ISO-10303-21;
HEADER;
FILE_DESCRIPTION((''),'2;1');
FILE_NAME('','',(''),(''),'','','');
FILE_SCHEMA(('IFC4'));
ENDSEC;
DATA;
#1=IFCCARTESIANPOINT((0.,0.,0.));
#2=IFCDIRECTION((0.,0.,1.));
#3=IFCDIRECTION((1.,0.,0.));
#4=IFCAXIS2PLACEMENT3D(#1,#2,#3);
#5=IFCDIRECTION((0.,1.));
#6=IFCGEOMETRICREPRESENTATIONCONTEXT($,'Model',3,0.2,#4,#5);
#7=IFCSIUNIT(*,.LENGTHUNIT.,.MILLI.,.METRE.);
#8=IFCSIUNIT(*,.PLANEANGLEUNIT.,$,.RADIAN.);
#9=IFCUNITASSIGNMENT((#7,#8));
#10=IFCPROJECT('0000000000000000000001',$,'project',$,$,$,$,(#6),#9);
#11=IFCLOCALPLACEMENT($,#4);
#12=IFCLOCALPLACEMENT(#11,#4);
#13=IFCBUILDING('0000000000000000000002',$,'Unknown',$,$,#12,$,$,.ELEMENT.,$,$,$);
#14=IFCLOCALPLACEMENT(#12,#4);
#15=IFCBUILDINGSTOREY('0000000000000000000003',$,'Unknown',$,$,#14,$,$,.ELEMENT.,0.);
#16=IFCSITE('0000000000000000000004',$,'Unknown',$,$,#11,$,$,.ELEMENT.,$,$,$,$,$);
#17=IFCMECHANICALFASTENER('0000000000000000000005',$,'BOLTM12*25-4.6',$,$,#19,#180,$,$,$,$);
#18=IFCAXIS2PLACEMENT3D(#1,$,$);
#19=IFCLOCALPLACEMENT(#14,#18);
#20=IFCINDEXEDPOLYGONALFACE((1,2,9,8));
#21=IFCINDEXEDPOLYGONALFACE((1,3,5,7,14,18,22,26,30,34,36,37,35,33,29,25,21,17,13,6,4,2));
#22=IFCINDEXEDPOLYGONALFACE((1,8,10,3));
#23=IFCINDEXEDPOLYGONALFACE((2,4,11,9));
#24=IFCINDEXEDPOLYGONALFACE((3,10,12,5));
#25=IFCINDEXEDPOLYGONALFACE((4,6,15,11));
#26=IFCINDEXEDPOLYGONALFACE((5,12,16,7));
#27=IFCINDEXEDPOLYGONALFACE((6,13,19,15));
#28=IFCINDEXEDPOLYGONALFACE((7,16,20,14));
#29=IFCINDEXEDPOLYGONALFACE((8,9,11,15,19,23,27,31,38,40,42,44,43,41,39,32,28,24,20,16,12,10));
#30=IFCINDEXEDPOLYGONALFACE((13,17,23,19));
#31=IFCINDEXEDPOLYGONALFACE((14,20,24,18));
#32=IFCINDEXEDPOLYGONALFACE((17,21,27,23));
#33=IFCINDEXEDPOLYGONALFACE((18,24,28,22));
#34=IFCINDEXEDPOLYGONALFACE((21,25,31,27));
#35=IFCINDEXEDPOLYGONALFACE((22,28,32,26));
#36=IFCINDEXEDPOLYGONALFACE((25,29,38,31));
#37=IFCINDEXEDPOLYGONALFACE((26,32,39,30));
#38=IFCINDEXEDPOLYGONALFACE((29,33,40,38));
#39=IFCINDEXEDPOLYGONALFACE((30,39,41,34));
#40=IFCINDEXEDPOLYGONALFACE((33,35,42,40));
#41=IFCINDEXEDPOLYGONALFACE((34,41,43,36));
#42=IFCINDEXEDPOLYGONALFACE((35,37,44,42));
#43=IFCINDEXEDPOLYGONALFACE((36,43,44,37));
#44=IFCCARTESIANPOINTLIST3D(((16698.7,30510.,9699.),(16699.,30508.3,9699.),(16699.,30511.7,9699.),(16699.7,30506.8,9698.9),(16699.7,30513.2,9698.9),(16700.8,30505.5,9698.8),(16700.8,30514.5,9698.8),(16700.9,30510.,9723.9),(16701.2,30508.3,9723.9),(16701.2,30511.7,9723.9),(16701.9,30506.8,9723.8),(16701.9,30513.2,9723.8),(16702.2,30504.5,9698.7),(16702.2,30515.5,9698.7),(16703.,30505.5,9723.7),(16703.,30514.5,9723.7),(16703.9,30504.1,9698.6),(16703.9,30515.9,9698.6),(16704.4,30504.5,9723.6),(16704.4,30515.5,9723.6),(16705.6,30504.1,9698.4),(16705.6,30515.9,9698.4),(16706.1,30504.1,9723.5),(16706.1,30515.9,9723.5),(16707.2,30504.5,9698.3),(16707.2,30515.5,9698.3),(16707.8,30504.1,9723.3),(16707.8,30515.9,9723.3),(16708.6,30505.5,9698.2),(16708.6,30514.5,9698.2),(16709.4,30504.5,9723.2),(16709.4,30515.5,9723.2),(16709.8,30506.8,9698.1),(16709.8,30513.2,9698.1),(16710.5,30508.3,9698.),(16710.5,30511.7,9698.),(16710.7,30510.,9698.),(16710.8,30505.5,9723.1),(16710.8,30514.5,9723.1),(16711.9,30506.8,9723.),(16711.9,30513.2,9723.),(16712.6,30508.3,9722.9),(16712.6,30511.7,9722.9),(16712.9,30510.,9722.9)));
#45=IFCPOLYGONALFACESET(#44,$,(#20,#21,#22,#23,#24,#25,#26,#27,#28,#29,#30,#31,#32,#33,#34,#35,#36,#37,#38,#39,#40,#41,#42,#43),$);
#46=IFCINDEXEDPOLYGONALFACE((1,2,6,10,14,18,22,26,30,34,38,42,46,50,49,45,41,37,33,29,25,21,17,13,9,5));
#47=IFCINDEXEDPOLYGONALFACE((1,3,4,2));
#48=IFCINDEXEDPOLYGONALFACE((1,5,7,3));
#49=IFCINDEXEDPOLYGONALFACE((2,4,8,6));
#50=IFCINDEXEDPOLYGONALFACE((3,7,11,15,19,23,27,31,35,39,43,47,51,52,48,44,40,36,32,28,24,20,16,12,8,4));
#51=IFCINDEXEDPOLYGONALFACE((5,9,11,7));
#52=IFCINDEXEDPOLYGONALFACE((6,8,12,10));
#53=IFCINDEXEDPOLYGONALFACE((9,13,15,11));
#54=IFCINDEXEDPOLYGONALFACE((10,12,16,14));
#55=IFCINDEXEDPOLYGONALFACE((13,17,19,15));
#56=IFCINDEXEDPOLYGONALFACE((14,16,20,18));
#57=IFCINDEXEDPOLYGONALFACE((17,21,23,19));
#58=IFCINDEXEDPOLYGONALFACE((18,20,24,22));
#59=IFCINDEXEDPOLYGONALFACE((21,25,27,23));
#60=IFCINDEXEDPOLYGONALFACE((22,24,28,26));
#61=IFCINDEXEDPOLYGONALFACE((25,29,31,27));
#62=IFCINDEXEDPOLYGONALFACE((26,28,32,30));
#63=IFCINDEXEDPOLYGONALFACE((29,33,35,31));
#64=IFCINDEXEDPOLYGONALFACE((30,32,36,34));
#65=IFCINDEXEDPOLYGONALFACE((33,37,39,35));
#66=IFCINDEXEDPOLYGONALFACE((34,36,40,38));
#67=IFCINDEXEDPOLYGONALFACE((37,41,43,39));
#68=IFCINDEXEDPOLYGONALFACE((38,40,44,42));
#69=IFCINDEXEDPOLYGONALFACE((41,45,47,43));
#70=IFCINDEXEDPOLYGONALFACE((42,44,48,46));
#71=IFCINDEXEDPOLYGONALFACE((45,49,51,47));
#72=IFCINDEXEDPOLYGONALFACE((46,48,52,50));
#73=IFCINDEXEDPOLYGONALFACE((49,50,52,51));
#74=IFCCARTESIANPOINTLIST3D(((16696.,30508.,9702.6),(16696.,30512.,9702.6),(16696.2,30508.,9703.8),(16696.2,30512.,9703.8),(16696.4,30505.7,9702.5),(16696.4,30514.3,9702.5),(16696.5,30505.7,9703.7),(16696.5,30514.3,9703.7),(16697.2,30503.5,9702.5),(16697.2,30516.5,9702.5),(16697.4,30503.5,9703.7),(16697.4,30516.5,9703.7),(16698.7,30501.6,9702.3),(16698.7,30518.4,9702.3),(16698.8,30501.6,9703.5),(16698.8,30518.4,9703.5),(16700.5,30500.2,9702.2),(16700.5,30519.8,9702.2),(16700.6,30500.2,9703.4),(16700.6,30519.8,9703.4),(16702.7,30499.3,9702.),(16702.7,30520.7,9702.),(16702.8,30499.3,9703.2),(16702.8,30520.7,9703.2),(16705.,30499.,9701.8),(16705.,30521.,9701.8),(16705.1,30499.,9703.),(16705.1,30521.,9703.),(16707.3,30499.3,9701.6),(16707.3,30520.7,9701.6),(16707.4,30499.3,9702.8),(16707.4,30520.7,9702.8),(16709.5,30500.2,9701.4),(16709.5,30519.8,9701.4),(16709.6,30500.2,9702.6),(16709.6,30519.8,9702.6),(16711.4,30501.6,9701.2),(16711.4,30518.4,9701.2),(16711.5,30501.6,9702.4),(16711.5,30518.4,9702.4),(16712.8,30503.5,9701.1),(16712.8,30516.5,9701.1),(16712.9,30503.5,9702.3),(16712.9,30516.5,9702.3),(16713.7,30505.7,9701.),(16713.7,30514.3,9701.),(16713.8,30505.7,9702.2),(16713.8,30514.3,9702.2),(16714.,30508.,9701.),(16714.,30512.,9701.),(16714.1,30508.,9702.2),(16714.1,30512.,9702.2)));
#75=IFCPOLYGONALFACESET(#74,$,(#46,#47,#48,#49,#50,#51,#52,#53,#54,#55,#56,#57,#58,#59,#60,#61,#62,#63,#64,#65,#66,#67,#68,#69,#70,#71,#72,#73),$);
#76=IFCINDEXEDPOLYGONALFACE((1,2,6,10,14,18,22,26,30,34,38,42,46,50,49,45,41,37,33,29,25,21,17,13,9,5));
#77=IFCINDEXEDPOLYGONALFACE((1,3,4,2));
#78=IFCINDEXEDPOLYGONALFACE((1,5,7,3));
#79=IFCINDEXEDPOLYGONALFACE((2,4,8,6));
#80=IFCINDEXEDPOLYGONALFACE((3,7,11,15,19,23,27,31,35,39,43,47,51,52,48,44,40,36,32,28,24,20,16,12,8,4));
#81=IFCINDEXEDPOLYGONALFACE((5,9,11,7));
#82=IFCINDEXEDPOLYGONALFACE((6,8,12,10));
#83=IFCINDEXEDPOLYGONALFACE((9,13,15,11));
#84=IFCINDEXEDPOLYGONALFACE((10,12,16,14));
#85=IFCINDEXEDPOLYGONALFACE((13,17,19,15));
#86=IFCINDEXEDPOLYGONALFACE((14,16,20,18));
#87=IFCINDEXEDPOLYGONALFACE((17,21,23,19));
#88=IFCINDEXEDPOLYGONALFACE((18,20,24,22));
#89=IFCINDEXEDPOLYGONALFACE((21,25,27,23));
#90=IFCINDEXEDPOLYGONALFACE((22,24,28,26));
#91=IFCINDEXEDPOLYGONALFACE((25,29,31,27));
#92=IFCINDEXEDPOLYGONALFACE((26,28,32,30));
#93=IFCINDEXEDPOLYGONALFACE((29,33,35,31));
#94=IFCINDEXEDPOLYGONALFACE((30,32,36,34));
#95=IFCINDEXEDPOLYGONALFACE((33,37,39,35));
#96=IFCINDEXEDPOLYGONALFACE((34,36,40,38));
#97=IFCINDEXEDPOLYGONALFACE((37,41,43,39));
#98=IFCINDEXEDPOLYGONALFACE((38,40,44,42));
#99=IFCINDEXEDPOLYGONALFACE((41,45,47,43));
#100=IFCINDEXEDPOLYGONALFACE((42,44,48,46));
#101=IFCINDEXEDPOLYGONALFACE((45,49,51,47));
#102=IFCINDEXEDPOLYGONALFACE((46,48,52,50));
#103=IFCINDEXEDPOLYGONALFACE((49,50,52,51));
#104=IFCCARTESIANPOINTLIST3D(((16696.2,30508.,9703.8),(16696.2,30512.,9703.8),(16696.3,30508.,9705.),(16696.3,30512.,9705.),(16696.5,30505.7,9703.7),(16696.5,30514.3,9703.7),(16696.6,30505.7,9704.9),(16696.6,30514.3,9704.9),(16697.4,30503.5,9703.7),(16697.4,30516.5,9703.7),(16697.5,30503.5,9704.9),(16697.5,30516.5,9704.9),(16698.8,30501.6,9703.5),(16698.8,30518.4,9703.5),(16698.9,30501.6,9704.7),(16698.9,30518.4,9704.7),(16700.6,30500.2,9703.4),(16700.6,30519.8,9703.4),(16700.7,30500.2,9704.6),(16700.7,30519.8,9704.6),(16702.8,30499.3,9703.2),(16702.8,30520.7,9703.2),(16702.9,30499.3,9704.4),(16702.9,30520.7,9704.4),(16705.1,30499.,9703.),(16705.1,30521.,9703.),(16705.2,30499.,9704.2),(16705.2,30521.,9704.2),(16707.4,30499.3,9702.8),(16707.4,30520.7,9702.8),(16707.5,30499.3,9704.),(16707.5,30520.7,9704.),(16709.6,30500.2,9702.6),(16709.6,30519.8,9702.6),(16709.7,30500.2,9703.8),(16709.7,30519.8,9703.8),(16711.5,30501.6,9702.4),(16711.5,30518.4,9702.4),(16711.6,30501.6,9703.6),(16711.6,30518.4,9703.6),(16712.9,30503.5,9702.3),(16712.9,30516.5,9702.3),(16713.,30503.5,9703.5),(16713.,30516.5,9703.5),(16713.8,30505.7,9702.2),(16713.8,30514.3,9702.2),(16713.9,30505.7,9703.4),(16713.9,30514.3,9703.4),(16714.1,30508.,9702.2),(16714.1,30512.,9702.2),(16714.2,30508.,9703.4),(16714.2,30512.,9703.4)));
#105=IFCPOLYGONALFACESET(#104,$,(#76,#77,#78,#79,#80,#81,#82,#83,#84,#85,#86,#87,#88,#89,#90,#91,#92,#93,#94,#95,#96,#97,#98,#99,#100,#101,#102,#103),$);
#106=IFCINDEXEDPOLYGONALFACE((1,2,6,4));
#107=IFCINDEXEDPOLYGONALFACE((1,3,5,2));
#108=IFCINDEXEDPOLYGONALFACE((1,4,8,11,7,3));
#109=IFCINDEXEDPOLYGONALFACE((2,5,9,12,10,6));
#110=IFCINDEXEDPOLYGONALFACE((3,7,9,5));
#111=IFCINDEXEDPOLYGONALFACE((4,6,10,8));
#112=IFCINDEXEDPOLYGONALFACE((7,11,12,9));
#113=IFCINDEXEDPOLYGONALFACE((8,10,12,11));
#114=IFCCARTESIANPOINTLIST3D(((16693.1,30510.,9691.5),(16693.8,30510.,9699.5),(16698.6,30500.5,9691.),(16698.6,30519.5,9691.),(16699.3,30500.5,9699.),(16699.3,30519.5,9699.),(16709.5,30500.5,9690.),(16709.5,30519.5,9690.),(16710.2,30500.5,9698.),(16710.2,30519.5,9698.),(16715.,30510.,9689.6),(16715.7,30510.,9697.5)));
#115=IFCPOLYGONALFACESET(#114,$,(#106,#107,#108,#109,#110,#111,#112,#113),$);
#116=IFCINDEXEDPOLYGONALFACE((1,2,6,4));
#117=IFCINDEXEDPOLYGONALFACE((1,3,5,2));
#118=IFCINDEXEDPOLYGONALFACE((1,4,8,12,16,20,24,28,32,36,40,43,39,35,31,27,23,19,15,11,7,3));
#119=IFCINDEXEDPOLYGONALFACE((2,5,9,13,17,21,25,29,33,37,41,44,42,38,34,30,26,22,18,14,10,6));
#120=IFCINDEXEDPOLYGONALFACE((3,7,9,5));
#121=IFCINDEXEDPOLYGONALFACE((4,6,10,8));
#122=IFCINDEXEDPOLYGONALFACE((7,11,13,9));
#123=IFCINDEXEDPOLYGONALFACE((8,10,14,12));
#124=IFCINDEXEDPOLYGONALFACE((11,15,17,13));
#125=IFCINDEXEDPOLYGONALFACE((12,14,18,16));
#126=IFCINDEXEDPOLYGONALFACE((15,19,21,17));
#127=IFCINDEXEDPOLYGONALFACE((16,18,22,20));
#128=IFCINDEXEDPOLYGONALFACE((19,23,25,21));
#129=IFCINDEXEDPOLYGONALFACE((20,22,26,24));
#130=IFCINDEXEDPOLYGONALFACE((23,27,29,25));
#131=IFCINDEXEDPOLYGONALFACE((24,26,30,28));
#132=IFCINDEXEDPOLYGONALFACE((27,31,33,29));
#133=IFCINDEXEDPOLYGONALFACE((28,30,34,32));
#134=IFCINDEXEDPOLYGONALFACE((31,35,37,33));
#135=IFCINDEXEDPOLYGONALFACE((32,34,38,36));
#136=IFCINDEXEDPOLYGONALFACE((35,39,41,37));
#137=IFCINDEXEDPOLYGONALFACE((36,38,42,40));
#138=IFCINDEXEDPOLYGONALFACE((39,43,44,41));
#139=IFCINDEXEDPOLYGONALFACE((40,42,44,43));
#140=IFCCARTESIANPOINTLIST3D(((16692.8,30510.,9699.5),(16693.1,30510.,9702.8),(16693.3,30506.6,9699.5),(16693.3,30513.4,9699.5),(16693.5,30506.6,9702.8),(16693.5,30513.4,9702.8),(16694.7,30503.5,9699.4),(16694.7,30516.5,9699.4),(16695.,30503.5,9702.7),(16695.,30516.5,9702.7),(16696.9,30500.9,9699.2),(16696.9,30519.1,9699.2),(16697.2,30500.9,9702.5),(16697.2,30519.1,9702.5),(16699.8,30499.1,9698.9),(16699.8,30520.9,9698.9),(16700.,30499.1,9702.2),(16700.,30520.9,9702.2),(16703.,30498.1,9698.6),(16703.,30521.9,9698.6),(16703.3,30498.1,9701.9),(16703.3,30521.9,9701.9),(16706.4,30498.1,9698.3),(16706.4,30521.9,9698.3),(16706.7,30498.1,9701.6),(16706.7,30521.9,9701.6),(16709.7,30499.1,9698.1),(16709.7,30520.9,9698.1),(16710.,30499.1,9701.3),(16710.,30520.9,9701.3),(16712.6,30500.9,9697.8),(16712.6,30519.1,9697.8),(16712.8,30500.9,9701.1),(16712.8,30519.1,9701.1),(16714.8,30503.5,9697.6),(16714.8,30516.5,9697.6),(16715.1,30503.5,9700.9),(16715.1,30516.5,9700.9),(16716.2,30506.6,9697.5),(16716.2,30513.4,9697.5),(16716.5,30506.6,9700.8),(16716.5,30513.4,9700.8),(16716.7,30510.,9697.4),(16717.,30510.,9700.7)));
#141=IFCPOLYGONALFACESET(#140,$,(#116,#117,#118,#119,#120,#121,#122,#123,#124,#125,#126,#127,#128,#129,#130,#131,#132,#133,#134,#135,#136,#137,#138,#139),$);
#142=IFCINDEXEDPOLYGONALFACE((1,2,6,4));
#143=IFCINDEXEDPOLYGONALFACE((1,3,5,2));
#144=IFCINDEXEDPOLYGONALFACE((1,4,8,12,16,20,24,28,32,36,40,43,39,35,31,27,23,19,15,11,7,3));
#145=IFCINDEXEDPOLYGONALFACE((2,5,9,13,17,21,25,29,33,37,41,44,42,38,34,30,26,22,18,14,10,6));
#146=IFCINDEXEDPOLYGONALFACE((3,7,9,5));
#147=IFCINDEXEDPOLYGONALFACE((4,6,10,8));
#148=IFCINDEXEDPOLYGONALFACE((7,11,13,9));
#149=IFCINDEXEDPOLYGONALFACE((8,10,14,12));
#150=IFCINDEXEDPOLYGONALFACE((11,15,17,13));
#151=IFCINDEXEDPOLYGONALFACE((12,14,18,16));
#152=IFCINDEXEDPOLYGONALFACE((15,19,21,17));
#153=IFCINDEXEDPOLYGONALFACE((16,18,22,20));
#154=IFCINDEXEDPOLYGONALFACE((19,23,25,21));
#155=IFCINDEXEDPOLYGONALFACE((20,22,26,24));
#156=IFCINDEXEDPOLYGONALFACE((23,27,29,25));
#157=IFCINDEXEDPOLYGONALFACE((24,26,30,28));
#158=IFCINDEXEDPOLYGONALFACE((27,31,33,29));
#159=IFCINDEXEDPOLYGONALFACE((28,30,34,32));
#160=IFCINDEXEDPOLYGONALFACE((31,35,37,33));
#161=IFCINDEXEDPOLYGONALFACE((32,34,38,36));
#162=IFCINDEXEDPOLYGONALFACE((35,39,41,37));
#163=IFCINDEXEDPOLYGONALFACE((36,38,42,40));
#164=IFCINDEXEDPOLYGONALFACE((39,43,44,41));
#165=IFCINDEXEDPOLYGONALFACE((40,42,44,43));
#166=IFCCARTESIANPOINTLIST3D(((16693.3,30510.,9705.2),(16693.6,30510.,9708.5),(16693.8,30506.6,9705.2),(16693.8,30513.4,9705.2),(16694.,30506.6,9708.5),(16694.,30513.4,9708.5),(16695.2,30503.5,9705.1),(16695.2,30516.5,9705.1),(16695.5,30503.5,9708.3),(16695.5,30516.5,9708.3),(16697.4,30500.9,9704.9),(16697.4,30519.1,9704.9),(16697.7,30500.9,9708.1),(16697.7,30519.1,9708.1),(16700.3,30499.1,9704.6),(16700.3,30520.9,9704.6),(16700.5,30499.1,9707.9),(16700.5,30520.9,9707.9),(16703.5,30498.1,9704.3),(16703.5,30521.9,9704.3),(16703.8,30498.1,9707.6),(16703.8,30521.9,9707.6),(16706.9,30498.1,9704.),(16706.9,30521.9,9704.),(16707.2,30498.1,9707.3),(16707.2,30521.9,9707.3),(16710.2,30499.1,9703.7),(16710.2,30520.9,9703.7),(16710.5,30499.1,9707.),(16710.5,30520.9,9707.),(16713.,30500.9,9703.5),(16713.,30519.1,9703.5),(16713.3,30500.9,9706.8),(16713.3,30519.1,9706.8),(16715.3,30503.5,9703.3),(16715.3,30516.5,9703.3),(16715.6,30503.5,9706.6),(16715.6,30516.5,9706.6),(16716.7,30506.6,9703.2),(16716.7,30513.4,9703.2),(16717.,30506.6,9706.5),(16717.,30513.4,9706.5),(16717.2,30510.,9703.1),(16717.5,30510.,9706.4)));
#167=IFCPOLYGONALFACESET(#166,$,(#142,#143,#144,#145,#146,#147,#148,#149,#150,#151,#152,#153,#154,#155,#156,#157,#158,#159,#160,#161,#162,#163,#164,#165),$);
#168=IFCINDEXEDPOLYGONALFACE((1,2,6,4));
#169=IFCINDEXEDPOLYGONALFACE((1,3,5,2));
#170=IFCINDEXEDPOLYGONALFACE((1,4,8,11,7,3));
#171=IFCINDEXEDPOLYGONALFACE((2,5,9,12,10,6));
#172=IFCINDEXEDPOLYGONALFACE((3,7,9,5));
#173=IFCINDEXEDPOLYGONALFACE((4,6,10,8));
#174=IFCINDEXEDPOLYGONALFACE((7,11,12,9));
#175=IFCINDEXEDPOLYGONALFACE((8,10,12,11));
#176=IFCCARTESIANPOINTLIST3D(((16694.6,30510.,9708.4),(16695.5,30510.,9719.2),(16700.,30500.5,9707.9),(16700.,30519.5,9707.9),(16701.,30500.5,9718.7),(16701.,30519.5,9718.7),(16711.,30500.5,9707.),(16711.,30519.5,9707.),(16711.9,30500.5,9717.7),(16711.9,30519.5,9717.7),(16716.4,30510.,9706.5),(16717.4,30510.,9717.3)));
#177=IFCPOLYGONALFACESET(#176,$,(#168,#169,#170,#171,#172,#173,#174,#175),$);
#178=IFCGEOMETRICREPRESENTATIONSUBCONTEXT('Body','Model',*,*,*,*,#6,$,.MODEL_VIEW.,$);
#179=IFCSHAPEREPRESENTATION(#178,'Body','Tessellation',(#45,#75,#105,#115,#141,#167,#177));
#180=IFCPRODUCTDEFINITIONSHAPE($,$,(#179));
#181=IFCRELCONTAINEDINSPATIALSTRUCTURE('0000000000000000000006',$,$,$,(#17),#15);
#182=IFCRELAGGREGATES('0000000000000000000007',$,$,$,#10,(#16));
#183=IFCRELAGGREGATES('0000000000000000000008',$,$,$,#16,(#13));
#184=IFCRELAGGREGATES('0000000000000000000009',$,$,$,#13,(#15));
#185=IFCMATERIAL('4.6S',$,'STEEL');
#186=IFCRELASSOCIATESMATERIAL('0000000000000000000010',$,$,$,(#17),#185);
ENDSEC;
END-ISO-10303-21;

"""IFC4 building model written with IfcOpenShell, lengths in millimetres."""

from ifc_helpers import new_model, si_unit, direction, frame, origin_with_axes, place, context, subcontext, project, spatial, line, arc, indexed_curve, outline, extrude, source, transform, mapped, material, element, save


model = new_model("IFC4")

# Units and contexts
model_context = context("Model", 3, precision=0.2, world=origin_with_axes(), true_north=direction((0.0, 1.0)))
body_context = subcontext(model_context, "Body", "Model", "MODEL_VIEW")
ifc_project = project(units=[si_unit("LENGTHUNIT", "METRE", prefix="MILLI"), si_unit("PLANEANGLEUNIT", "RADIAN")], contexts=[model_context])

# Site, building, storey
site_placement = place(None, origin_with_axes())
site = spatial("IfcSite", under=ifc_project, at=site_placement, Name="Unknown", CompositionType="ELEMENT")
building_placement = place(site_placement, origin_with_axes())
building = spatial("IfcBuilding", under=site, at=building_placement, Name="Unknown", CompositionType="ELEMENT")
storey_placement = place(building_placement, origin_with_axes())
storey = spatial("IfcBuildingStorey", under=building, at=storey_placement, Name="Unknown", CompositionType="ELEMENT", Elevation=0.0)

# Mechanical fastener
ifc_material_1 = material(Name="4.6S", Category="STEEL")
shared_shape_1 = source(origin_with_axes(), body_context, "Body", "SweptSolid", [
    extrude(outline(indexed_curve([(6.0, 0.0), (0.0, 6.0), (-6.0, 0.0), (0.0, -6.0)], segments=[arc(1, 2, 3), arc(3, 4, 1)])), frame((0.0, 0.0, 4.8), z_axis=(0.0, 0.0, -1.0), x_axis=(0.0, 1.0, 0.0)), (0.0, 0.0, 1.0), 25.0),
    extrude(outline(indexed_curve([(0.0, 11.0), (6.4, 8.4), (9.0, 2.0), (9.0, -2.0), (6.4, -8.4), (0.0, -11.0), (-0.8, -11.0), (-9.0, -2.0), (-9.0, 2.0), (-6.4, 8.4)], segments=[arc(1, 2, 3), line(3, 4), arc(4, 5, 6), arc(6, 7, 8), line(8, 9), arc(9, 10, 1)])), frame((0.0, 0.0, 1.5), z_axis=(0.0, 0.0, -1.0), x_axis=(0.0, 1.0, 0.0)), (0.0, 0.0, 1.0), 1.2),
    extrude(outline(indexed_curve([(0.0, 11.0), (6.4, 8.4), (9.0, 2.0), (9.0, -2.0), (6.4, -8.4), (0.0, -11.0), (-0.8, -11.0), (-9.0, -2.0), (-9.0, 2.0), (-6.4, 8.4)], segments=[arc(1, 2, 3), line(3, 4), arc(4, 5, 6), arc(6, 7, 8), line(8, 9), arc(9, 10, 1)])), frame((0.0, 0.0, 0.3), z_axis=(0.0, 0.0, -1.0), x_axis=(0.0, 1.0, 0.0)), (0.0, 0.0, 1.0), 1.2),
    extrude(outline(indexed_curve([(11.0, 0.0), (5.5, 9.5), (-5.5, 9.5), (-11.0, 0.0), (-5.5, -9.5), (5.5, -9.5)], segments=[line(1, 2, 3, 4, 5, 6, 1)])), frame((0.0, 0.0, 12.8), z_axis=(0.0, 0.0, -1.0), x_axis=(0.0, 1.0, 0.0)), (0.0, 0.0, 1.0), 8.0),
    extrude(outline(indexed_curve([(12.0, 0.0), (0.0, 12.0), (-12.0, 0.0), (0.0, -12.0)], segments=[arc(1, 2, 3), arc(3, 4, 1)])), frame((0.0, 0.0, 4.8), z_axis=(0.0, 0.0, -1.0), x_axis=(0.0, 1.0, 0.0)), (0.0, 0.0, 1.0), 3.3),
    extrude(outline(indexed_curve([(12.0, 0.0), (0.0, 12.0), (-12.0, 0.0), (0.0, -12.0)], segments=[arc(1, 2, 3), arc(3, 4, 1)])), frame((0.0, 0.0, -0.9), z_axis=(0.0, 0.0, -1.0), x_axis=(0.0, 1.0, 0.0)), (0.0, 0.0, 1.0), 3.3),
    extrude(outline(indexed_curve([(11.0, 0.0), (5.5, 9.5), (-5.5, 9.5), (-11.0, 0.0), (-5.5, -9.5), (5.5, -9.5)], segments=[line(1, 2, 3, 4, 5, 6, 1)])), frame((0.0, 0.0, -4.2), z_axis=(0.0, 0.0, -1.0), x_axis=(0.0, 1.0, 0.0)), (0.0, 0.0, 1.0), 10.8),
])
for number, where, z_axis, x_axis, name in (
    (1, (16705.1, 30510.0, 9703.3), (-0.08716, 0.0, -0.996194), (0.0, 1.0, 0.0), "BOLTM12*25-4.6"),
):
    element("IfcMechanicalFastener", number, at=place(storey_placement, frame(where, z_axis=z_axis, x_axis=x_axis)), inside=storey, material=ifc_material_1, Name=name, context=body_context, shape_type="MappedRepresentation", body=[
        mapped(shared_shape_1, transform((0.0, 0.0, 0.0))),
    ])

save(model, "model.ifc")
